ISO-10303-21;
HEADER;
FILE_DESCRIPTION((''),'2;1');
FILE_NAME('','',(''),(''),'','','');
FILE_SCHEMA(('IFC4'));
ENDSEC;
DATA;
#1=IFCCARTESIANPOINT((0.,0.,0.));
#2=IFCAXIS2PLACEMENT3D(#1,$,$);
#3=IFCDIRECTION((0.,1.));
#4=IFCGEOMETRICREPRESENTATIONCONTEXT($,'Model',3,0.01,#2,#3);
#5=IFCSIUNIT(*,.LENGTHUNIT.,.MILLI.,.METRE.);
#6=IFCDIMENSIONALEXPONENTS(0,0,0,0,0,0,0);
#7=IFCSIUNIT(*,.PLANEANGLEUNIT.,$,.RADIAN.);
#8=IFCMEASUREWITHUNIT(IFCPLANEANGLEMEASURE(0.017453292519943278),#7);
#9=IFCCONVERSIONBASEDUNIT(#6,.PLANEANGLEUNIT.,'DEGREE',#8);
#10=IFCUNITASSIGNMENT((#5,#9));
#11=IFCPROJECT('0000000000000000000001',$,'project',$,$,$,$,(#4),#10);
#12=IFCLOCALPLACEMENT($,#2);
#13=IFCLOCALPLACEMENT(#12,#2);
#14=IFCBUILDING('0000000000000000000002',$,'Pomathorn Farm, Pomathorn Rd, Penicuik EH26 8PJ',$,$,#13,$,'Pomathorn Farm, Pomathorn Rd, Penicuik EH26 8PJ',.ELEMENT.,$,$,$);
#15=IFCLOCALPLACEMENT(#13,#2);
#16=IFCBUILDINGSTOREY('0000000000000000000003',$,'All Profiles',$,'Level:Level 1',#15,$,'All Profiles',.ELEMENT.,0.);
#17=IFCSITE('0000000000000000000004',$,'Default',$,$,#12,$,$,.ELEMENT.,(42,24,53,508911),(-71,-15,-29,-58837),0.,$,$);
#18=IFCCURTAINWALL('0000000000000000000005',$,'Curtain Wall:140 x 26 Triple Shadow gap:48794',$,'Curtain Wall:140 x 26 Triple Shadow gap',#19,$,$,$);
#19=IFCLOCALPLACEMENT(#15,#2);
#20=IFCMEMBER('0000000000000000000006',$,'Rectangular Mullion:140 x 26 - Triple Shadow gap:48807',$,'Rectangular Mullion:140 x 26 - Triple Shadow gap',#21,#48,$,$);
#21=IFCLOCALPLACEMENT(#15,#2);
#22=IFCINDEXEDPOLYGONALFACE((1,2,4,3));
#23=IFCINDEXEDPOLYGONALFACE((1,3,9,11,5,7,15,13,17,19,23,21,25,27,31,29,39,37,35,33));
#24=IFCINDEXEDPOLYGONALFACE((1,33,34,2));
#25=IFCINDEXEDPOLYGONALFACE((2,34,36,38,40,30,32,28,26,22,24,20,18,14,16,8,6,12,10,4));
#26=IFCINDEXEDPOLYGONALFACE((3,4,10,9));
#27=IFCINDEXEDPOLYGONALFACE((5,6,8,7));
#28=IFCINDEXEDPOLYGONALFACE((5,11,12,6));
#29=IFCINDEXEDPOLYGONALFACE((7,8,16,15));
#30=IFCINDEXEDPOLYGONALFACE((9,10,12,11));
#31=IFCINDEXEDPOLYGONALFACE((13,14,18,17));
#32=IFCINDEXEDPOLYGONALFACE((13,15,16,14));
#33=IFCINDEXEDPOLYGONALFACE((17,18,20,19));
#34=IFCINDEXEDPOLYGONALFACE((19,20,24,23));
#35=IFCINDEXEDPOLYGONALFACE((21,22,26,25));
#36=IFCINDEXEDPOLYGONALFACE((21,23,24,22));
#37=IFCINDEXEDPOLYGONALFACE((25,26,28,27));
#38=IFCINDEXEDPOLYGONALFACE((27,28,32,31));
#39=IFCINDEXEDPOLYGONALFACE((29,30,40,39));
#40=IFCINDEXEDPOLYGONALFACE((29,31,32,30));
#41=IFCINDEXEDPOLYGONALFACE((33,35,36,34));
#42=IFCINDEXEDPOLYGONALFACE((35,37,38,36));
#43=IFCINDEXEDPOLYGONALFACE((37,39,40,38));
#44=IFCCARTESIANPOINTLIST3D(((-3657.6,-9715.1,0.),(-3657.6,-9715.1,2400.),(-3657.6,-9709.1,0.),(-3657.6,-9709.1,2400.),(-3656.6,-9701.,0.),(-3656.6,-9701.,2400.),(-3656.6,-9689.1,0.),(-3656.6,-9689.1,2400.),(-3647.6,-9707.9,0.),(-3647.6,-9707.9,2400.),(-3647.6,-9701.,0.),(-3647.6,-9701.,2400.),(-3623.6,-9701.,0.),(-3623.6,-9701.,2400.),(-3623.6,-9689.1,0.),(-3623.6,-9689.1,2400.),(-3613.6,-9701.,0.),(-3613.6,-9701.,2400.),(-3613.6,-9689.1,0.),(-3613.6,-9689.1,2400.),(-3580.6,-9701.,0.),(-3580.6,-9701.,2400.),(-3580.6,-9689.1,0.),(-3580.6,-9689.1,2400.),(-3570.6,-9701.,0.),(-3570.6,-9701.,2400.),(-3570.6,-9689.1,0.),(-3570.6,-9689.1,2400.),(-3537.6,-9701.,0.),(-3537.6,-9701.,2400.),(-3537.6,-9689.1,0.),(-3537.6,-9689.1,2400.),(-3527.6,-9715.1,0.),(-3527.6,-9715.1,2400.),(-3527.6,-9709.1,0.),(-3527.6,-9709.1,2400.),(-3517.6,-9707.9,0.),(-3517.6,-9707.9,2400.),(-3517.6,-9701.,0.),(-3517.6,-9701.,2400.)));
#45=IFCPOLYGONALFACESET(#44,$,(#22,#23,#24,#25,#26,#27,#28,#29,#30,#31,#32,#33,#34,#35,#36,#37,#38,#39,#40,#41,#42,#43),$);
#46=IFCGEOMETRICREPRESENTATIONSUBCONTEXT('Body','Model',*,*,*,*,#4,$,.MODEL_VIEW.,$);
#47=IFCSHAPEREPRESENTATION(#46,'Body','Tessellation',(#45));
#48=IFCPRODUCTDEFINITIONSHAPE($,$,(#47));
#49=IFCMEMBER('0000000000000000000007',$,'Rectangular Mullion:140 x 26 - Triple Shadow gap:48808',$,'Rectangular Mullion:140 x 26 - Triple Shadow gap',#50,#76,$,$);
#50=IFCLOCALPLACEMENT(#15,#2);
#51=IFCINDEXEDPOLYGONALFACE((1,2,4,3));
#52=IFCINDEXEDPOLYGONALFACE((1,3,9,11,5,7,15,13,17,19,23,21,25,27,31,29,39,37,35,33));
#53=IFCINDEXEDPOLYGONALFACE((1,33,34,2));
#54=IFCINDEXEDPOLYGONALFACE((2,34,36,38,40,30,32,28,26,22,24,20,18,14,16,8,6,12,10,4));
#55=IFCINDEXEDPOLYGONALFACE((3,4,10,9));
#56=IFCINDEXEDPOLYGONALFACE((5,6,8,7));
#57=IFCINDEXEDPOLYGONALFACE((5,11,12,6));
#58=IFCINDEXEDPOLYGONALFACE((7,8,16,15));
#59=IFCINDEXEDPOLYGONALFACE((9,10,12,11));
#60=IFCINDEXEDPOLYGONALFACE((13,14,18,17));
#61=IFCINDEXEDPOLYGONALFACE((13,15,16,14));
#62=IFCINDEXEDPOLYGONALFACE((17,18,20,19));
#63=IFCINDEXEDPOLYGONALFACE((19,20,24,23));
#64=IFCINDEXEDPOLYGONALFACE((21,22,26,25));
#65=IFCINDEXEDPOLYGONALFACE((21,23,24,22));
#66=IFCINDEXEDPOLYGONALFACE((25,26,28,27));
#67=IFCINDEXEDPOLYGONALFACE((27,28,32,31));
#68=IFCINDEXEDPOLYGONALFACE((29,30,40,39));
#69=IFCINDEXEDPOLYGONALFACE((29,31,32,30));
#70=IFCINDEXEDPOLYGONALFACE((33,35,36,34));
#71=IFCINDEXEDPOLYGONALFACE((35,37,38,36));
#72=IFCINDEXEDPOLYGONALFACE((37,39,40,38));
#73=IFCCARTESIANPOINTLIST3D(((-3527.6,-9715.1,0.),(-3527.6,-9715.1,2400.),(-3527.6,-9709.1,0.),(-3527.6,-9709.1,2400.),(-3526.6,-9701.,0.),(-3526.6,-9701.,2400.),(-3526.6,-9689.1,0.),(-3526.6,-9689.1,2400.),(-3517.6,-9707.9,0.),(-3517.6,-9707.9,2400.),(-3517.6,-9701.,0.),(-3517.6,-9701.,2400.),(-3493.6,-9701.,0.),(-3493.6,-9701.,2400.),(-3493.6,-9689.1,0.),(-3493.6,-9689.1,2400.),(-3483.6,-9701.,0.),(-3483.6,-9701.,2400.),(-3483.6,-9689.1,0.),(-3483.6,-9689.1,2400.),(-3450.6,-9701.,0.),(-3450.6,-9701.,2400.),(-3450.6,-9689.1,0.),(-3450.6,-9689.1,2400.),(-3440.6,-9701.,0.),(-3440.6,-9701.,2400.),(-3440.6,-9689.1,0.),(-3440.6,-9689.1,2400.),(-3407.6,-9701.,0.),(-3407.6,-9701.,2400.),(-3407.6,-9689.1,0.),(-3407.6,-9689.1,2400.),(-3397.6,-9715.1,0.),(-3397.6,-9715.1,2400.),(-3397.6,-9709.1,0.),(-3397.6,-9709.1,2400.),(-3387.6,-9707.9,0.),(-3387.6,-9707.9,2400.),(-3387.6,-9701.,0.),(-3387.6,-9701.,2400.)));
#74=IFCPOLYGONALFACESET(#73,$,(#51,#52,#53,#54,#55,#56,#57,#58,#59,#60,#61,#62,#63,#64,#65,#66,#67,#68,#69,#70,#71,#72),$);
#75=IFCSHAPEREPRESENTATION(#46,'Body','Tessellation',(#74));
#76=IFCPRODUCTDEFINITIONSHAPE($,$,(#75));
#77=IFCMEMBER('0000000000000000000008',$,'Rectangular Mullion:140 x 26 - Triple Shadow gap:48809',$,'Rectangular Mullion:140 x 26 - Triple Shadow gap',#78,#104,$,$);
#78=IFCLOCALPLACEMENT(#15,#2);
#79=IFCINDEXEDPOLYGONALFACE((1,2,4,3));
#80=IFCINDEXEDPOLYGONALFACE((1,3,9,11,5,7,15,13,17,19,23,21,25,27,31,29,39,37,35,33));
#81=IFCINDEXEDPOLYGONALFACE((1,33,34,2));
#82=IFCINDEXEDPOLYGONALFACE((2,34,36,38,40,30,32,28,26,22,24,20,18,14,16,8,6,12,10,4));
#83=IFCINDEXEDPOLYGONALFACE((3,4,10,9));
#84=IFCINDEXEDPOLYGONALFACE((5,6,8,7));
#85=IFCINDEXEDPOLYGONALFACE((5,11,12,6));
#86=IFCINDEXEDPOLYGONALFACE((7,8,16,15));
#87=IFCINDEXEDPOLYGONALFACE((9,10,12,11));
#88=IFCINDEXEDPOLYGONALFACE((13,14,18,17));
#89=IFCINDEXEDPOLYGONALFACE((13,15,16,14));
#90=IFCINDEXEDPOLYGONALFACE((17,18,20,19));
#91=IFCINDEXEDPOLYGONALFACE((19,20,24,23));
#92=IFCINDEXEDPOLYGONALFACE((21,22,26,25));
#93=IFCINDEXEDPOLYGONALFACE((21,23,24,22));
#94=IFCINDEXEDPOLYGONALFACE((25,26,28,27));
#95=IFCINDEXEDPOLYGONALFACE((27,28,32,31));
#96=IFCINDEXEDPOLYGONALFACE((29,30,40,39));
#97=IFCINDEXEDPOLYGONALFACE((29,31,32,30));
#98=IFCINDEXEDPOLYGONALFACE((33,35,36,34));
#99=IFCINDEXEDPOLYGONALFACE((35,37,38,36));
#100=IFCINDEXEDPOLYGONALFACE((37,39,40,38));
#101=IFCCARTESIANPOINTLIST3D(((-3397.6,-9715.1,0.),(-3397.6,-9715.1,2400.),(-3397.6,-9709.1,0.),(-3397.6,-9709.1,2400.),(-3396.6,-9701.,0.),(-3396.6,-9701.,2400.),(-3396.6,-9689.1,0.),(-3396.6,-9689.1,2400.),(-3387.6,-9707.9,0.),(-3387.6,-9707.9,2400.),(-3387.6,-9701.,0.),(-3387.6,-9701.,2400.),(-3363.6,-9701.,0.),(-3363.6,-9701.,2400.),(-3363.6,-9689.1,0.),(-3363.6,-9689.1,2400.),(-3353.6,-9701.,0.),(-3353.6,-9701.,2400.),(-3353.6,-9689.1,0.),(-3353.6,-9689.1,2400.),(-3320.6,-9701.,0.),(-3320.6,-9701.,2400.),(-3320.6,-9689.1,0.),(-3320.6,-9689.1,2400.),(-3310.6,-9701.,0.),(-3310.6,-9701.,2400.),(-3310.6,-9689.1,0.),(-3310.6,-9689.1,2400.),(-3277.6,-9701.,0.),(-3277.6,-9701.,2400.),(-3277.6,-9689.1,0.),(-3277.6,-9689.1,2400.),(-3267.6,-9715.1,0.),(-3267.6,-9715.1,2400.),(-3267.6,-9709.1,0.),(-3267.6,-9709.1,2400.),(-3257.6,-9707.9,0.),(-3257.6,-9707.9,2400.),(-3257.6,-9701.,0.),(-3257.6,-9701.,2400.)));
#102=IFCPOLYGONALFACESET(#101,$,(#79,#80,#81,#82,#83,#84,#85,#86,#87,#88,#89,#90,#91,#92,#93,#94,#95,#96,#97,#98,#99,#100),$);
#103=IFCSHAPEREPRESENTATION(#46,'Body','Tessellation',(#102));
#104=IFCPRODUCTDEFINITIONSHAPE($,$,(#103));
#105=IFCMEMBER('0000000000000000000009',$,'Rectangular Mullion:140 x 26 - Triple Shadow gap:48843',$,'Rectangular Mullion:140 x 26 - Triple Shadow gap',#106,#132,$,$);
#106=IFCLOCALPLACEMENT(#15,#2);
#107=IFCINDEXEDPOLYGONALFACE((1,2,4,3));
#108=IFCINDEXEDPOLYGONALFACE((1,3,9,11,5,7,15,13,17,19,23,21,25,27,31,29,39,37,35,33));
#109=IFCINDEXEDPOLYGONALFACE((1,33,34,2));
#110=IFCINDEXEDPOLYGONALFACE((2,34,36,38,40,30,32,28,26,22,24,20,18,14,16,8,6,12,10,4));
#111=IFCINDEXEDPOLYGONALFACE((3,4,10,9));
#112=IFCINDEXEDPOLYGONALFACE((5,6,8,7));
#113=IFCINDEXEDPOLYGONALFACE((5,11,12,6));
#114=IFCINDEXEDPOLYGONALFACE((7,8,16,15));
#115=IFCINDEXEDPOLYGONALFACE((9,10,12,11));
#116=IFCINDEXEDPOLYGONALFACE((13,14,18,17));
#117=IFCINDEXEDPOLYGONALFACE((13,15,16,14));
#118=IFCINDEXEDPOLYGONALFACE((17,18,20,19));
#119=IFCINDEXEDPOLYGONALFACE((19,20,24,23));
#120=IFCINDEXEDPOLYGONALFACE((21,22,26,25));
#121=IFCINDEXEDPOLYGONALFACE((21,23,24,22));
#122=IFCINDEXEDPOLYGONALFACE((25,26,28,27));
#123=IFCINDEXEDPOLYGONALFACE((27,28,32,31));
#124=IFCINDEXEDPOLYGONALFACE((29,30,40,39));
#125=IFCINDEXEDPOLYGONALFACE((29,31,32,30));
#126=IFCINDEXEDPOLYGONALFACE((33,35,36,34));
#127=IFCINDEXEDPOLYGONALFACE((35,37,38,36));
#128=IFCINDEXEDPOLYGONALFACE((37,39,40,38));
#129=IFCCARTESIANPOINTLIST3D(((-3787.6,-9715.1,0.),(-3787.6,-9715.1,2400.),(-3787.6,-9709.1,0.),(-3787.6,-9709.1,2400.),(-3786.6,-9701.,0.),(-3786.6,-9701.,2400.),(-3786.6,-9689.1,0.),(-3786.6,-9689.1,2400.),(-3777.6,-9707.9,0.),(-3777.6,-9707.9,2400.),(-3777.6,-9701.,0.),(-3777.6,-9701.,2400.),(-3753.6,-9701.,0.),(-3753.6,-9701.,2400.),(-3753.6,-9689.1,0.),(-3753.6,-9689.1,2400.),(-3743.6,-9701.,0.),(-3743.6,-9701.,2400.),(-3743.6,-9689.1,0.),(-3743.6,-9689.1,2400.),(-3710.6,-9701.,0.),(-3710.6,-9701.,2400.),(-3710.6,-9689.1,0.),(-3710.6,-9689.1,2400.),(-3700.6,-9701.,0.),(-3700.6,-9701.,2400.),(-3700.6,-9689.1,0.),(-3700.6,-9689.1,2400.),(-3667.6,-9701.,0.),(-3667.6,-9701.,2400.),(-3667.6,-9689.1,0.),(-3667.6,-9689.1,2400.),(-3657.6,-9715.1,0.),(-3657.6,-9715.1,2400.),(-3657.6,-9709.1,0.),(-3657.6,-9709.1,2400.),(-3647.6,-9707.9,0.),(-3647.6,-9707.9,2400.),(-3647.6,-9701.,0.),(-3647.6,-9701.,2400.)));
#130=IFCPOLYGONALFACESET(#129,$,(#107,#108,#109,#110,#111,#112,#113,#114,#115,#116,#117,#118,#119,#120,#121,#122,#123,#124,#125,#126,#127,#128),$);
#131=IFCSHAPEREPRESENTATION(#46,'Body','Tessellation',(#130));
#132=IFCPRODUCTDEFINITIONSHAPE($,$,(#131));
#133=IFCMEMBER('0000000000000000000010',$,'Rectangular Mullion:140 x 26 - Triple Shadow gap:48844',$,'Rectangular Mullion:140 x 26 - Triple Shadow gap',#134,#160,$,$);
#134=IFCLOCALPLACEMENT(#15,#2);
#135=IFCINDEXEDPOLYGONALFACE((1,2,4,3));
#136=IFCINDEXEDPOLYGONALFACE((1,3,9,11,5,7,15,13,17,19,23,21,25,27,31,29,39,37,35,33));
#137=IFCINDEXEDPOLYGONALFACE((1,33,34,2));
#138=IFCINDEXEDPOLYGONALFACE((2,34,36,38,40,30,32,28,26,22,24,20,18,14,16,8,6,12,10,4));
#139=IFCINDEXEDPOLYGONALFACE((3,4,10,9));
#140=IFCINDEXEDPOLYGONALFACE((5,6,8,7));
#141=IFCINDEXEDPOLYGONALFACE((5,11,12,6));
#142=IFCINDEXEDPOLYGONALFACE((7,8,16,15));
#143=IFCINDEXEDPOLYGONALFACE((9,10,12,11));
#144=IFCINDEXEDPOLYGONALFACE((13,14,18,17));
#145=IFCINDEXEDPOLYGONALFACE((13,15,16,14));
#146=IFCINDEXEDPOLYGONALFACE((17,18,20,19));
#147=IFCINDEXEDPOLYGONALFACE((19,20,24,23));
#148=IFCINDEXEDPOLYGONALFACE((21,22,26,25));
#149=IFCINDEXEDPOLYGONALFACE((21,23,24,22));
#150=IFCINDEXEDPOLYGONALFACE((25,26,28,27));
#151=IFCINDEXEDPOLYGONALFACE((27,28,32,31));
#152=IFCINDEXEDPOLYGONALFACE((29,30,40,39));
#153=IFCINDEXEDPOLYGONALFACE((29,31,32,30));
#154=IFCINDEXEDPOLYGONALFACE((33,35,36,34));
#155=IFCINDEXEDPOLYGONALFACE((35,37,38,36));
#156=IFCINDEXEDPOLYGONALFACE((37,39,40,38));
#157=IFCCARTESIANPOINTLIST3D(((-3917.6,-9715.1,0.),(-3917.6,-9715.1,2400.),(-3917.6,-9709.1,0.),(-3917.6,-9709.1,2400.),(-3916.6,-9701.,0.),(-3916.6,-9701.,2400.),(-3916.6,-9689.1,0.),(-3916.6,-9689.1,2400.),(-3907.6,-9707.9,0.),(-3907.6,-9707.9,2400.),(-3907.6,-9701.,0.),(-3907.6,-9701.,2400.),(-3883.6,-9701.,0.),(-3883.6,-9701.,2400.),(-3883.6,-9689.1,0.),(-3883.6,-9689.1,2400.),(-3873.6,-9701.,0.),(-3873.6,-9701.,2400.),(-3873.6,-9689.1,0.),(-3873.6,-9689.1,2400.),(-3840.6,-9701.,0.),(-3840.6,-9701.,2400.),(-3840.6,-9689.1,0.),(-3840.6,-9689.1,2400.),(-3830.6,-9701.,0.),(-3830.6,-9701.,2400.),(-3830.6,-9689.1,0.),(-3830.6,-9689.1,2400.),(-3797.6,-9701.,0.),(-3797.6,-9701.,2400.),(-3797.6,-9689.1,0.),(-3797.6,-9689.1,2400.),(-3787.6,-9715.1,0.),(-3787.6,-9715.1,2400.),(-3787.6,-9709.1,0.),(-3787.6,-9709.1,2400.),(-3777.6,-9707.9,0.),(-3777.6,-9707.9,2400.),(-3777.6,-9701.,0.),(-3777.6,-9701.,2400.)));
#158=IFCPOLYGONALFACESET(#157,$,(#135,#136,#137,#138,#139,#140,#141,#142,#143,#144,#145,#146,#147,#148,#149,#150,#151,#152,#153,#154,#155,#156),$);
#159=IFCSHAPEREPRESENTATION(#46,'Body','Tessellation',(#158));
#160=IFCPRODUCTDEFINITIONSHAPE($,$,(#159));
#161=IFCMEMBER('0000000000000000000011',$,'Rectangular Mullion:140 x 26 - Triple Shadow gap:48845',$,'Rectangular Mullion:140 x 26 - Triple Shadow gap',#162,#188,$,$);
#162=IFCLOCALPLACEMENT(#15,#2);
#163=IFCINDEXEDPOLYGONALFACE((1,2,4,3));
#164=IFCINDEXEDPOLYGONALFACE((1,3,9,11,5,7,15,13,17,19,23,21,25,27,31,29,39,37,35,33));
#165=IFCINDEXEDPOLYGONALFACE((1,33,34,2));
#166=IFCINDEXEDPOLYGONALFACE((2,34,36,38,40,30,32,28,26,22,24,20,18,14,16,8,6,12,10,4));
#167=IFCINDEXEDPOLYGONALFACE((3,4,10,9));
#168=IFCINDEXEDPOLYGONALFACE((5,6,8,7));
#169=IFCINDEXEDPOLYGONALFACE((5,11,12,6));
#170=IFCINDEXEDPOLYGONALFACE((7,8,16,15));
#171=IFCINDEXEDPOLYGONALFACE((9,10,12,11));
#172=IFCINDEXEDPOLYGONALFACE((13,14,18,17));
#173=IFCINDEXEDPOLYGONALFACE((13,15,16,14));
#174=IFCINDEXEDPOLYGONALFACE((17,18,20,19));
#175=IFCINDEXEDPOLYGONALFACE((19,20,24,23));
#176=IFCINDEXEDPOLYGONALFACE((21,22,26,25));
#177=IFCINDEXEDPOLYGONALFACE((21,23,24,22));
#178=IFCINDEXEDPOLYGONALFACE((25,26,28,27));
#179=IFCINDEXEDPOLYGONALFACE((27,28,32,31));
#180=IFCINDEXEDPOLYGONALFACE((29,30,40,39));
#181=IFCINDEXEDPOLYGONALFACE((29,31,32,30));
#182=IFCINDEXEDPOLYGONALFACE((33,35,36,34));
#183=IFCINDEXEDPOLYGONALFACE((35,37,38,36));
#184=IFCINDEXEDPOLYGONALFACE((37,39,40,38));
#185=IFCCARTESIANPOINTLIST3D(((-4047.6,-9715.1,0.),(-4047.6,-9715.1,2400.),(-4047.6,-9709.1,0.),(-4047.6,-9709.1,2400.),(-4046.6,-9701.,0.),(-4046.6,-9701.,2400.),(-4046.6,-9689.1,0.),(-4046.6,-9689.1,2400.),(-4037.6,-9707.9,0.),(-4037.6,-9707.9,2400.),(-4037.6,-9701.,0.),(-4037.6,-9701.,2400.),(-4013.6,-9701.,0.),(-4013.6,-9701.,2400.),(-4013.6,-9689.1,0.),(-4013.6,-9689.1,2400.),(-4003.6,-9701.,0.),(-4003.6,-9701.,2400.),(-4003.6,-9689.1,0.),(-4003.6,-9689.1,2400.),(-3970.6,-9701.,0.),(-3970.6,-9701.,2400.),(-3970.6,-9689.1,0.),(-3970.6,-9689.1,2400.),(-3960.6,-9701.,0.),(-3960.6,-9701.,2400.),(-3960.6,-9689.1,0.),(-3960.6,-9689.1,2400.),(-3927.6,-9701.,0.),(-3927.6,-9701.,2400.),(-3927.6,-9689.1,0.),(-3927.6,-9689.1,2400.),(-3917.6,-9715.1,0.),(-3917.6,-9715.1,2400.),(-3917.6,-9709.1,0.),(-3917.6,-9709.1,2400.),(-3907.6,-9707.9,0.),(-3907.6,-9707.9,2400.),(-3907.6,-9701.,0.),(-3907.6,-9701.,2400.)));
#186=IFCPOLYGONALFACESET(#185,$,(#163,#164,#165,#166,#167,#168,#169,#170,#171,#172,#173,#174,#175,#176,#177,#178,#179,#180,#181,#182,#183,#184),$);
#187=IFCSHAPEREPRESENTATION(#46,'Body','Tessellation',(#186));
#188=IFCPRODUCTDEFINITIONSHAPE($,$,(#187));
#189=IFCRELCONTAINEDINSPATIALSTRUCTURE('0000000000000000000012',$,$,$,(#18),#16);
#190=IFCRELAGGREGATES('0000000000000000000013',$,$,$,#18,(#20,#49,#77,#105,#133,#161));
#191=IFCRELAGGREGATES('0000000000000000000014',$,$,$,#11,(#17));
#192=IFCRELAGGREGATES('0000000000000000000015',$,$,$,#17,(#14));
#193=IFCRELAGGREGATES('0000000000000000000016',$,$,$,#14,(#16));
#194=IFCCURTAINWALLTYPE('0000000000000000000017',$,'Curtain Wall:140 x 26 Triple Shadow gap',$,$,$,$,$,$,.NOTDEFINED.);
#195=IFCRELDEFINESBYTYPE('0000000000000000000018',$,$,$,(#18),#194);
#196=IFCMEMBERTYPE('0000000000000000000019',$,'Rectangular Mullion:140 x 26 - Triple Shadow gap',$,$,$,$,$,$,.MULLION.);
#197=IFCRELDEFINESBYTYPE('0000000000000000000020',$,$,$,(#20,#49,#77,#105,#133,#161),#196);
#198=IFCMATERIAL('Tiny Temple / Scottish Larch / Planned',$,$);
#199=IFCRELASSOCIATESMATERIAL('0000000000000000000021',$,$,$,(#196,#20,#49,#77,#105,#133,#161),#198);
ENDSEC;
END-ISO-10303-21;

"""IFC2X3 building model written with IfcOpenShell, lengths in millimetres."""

from ifc_helpers import new_model, entity, si_unit, converted_unit, direction, frame, origin, place, context, subcontext, project, spatial, polyline, outline, extrude, source, transform, mapped, material, type_object, type_shapes, element, aggregate, save


model = new_model("IFC2X3")

# Units and contexts
model_context = context("Model", 3, precision=0.01, world=origin(), true_north=direction((0.0, 1.0)))
body_context = subcontext(model_context, "Body", "Model", "MODEL_VIEW")
ifc_project = project(units=[si_unit("LENGTHUNIT", "METRE", prefix="MILLI"), converted_unit("PLANEANGLEUNIT", "DEGREE", entity("IfcPlaneAngleMeasure", 0.017453292519943278), si_unit("PLANEANGLEUNIT", "RADIAN"), dimensions=[0, 0, 0, 0, 0, 0, 0])], contexts=[model_context])

# Site, building, storey
site_placement = place(None, origin())
site = spatial("IfcSite", under=ifc_project, at=site_placement, Name="Default", CompositionType="ELEMENT", RefLatitude=(42, 24, 53, 508911), RefLongitude=(-71, -15, -29, -58837), RefElevation=0.0)
building_placement = place(site_placement, origin())
building = spatial("IfcBuilding", under=site, at=building_placement, Name="Pomathorn Farm, Pomathorn Rd, Penicuik EH26 8PJ", LongName="Pomathorn Farm, Pomathorn Rd, Penicuik EH26 8PJ", CompositionType="ELEMENT")
storey_placement = place(building_placement, origin())
storey = spatial("IfcBuildingStorey", under=building, at=storey_placement, Name="All Profiles", ObjectType="Level:Level 1", LongName="All Profiles", CompositionType="ELEMENT", Elevation=0.0)

# Curtain wall, members
ifc_material = material(Name="Tiny Temple / Scottish Larch / Planned")
curtain_wall_type_1 = type_object("IfcCurtainWallType", Name="Curtain Wall:140 x 26 Triple Shadow gap", PredefinedType="NOTDEFINED")
curtain_wall_1_placement = place(storey_placement, origin())
curtain_wall_1 = element("IfcCurtainWall", 1, at=curtain_wall_1_placement, inside=storey, type_object=curtain_wall_type_1, Name="Curtain Wall:140 x 26 Triple Shadow gap:48794", ObjectType="Curtain Wall:140 x 26 Triple Shadow gap")
member_type_1 = type_object("IfcMemberType", Name="Rectangular Mullion:140 x 26 - Triple Shadow gap", PredefinedType="MULLION", material=ifc_material)
shared_shape_1 = source(origin(), body_context, "Body", "SweptSolid", [
    extrude(outline(polyline([(-64.9, -0.9), (-65.6, -6.8), (63.4, -22.7), (64.1, -16.7), (74.2, -16.7), (75.1, -9.8), (55.2, -7.4), (56.7, 4.3), (23.9, 8.4), (22.5, -3.4), (12.5, -2.2), (14.0, 9.6), (-18.8, 13.6), (-20.2, 1.9), (-30.1, 3.1), (-28.7, 14.8), (-61.5, 18.8), (-62.9, 7.1), (-54.0, 6.0), (-54.8, -0.9), (-64.9, -0.9)])), frame((-75.7, -14.8, -2400.0), z_axis=(0.0, 0.0, -1.0), x_axis=(0.992546, -0.121869, 0.0)), (0.0, 0.0, -1.0), 2400.0),
])
type_shapes(member_type_1, [shared_shape_1])
member_1_placement = place(curtain_wall_1_placement, frame((-3517.6, -9715.1, 0.0), z_axis=(0.0, 0.0, -1.0), x_axis=(1.0, 0.0, 0.0)))
member_1 = element("IfcMember", 2, at=member_1_placement, type_object=member_type_1, material=ifc_material, Name="Rectangular Mullion:140 x 26 - Triple Shadow gap:48807", ObjectType="Rectangular Mullion:140 x 26 - Triple Shadow gap", context=body_context, shape_type="MappedRepresentation", body=[
    mapped(shared_shape_1, transform((0.0, 0.0, 0.0), scale=1.0)),
])
member_2_placement = place(curtain_wall_1_placement, frame((-3387.6, -9715.1, 0.0), z_axis=(0.0, 0.0, -1.0), x_axis=(1.0, 0.0, 0.0)))
member_2 = element("IfcMember", 3, at=member_2_placement, type_object=member_type_1, material=ifc_material, Name="Rectangular Mullion:140 x 26 - Triple Shadow gap:48808", ObjectType="Rectangular Mullion:140 x 26 - Triple Shadow gap", context=body_context, shape_type="MappedRepresentation", body=[
    mapped(shared_shape_1, transform((0.0, 0.0, 0.0), scale=1.0)),
])
member_3_placement = place(curtain_wall_1_placement, frame((-3257.6, -9715.1, 0.0), z_axis=(0.0, 0.0, -1.0), x_axis=(1.0, 0.0, 0.0)))
member_3 = element("IfcMember", 4, at=member_3_placement, type_object=member_type_1, material=ifc_material, Name="Rectangular Mullion:140 x 26 - Triple Shadow gap:48809", ObjectType="Rectangular Mullion:140 x 26 - Triple Shadow gap", context=body_context, shape_type="MappedRepresentation", body=[
    mapped(shared_shape_1, transform((0.0, 0.0, 0.0), scale=1.0)),
])
member_4_placement = place(curtain_wall_1_placement, frame((-3647.6, -9715.1, 0.0), z_axis=(0.0, 0.0, -1.0), x_axis=(1.0, 0.0, 0.0)))
member_4 = element("IfcMember", 5, at=member_4_placement, type_object=member_type_1, material=ifc_material, Name="Rectangular Mullion:140 x 26 - Triple Shadow gap:48843", ObjectType="Rectangular Mullion:140 x 26 - Triple Shadow gap", context=body_context, shape_type="MappedRepresentation", body=[
    mapped(shared_shape_1, transform((0.0, 0.0, 0.0), scale=1.0)),
])
member_5_placement = place(curtain_wall_1_placement, frame((-3777.6, -9715.1, 0.0), z_axis=(0.0, 0.0, -1.0), x_axis=(1.0, 0.0, 0.0)))
member_5 = element("IfcMember", 6, at=member_5_placement, type_object=member_type_1, material=ifc_material, Name="Rectangular Mullion:140 x 26 - Triple Shadow gap:48844", ObjectType="Rectangular Mullion:140 x 26 - Triple Shadow gap", context=body_context, shape_type="MappedRepresentation", body=[
    mapped(shared_shape_1, transform((0.0, 0.0, 0.0), scale=1.0)),
])
member_6_placement = place(curtain_wall_1_placement, frame((-3907.6, -9715.1, 0.0), z_axis=(0.0, 0.0, -1.0), x_axis=(1.0, 0.0, 0.0)))
member_6 = element("IfcMember", 7, at=member_6_placement, type_object=member_type_1, material=ifc_material, Name="Rectangular Mullion:140 x 26 - Triple Shadow gap:48845", ObjectType="Rectangular Mullion:140 x 26 - Triple Shadow gap", context=body_context, shape_type="MappedRepresentation", body=[
    mapped(shared_shape_1, transform((0.0, 0.0, 0.0), scale=1.0)),
])
aggregate(curtain_wall_1, [member_1, member_2, member_3, member_4, member_5, member_6])

save(model, "model.ifc")
